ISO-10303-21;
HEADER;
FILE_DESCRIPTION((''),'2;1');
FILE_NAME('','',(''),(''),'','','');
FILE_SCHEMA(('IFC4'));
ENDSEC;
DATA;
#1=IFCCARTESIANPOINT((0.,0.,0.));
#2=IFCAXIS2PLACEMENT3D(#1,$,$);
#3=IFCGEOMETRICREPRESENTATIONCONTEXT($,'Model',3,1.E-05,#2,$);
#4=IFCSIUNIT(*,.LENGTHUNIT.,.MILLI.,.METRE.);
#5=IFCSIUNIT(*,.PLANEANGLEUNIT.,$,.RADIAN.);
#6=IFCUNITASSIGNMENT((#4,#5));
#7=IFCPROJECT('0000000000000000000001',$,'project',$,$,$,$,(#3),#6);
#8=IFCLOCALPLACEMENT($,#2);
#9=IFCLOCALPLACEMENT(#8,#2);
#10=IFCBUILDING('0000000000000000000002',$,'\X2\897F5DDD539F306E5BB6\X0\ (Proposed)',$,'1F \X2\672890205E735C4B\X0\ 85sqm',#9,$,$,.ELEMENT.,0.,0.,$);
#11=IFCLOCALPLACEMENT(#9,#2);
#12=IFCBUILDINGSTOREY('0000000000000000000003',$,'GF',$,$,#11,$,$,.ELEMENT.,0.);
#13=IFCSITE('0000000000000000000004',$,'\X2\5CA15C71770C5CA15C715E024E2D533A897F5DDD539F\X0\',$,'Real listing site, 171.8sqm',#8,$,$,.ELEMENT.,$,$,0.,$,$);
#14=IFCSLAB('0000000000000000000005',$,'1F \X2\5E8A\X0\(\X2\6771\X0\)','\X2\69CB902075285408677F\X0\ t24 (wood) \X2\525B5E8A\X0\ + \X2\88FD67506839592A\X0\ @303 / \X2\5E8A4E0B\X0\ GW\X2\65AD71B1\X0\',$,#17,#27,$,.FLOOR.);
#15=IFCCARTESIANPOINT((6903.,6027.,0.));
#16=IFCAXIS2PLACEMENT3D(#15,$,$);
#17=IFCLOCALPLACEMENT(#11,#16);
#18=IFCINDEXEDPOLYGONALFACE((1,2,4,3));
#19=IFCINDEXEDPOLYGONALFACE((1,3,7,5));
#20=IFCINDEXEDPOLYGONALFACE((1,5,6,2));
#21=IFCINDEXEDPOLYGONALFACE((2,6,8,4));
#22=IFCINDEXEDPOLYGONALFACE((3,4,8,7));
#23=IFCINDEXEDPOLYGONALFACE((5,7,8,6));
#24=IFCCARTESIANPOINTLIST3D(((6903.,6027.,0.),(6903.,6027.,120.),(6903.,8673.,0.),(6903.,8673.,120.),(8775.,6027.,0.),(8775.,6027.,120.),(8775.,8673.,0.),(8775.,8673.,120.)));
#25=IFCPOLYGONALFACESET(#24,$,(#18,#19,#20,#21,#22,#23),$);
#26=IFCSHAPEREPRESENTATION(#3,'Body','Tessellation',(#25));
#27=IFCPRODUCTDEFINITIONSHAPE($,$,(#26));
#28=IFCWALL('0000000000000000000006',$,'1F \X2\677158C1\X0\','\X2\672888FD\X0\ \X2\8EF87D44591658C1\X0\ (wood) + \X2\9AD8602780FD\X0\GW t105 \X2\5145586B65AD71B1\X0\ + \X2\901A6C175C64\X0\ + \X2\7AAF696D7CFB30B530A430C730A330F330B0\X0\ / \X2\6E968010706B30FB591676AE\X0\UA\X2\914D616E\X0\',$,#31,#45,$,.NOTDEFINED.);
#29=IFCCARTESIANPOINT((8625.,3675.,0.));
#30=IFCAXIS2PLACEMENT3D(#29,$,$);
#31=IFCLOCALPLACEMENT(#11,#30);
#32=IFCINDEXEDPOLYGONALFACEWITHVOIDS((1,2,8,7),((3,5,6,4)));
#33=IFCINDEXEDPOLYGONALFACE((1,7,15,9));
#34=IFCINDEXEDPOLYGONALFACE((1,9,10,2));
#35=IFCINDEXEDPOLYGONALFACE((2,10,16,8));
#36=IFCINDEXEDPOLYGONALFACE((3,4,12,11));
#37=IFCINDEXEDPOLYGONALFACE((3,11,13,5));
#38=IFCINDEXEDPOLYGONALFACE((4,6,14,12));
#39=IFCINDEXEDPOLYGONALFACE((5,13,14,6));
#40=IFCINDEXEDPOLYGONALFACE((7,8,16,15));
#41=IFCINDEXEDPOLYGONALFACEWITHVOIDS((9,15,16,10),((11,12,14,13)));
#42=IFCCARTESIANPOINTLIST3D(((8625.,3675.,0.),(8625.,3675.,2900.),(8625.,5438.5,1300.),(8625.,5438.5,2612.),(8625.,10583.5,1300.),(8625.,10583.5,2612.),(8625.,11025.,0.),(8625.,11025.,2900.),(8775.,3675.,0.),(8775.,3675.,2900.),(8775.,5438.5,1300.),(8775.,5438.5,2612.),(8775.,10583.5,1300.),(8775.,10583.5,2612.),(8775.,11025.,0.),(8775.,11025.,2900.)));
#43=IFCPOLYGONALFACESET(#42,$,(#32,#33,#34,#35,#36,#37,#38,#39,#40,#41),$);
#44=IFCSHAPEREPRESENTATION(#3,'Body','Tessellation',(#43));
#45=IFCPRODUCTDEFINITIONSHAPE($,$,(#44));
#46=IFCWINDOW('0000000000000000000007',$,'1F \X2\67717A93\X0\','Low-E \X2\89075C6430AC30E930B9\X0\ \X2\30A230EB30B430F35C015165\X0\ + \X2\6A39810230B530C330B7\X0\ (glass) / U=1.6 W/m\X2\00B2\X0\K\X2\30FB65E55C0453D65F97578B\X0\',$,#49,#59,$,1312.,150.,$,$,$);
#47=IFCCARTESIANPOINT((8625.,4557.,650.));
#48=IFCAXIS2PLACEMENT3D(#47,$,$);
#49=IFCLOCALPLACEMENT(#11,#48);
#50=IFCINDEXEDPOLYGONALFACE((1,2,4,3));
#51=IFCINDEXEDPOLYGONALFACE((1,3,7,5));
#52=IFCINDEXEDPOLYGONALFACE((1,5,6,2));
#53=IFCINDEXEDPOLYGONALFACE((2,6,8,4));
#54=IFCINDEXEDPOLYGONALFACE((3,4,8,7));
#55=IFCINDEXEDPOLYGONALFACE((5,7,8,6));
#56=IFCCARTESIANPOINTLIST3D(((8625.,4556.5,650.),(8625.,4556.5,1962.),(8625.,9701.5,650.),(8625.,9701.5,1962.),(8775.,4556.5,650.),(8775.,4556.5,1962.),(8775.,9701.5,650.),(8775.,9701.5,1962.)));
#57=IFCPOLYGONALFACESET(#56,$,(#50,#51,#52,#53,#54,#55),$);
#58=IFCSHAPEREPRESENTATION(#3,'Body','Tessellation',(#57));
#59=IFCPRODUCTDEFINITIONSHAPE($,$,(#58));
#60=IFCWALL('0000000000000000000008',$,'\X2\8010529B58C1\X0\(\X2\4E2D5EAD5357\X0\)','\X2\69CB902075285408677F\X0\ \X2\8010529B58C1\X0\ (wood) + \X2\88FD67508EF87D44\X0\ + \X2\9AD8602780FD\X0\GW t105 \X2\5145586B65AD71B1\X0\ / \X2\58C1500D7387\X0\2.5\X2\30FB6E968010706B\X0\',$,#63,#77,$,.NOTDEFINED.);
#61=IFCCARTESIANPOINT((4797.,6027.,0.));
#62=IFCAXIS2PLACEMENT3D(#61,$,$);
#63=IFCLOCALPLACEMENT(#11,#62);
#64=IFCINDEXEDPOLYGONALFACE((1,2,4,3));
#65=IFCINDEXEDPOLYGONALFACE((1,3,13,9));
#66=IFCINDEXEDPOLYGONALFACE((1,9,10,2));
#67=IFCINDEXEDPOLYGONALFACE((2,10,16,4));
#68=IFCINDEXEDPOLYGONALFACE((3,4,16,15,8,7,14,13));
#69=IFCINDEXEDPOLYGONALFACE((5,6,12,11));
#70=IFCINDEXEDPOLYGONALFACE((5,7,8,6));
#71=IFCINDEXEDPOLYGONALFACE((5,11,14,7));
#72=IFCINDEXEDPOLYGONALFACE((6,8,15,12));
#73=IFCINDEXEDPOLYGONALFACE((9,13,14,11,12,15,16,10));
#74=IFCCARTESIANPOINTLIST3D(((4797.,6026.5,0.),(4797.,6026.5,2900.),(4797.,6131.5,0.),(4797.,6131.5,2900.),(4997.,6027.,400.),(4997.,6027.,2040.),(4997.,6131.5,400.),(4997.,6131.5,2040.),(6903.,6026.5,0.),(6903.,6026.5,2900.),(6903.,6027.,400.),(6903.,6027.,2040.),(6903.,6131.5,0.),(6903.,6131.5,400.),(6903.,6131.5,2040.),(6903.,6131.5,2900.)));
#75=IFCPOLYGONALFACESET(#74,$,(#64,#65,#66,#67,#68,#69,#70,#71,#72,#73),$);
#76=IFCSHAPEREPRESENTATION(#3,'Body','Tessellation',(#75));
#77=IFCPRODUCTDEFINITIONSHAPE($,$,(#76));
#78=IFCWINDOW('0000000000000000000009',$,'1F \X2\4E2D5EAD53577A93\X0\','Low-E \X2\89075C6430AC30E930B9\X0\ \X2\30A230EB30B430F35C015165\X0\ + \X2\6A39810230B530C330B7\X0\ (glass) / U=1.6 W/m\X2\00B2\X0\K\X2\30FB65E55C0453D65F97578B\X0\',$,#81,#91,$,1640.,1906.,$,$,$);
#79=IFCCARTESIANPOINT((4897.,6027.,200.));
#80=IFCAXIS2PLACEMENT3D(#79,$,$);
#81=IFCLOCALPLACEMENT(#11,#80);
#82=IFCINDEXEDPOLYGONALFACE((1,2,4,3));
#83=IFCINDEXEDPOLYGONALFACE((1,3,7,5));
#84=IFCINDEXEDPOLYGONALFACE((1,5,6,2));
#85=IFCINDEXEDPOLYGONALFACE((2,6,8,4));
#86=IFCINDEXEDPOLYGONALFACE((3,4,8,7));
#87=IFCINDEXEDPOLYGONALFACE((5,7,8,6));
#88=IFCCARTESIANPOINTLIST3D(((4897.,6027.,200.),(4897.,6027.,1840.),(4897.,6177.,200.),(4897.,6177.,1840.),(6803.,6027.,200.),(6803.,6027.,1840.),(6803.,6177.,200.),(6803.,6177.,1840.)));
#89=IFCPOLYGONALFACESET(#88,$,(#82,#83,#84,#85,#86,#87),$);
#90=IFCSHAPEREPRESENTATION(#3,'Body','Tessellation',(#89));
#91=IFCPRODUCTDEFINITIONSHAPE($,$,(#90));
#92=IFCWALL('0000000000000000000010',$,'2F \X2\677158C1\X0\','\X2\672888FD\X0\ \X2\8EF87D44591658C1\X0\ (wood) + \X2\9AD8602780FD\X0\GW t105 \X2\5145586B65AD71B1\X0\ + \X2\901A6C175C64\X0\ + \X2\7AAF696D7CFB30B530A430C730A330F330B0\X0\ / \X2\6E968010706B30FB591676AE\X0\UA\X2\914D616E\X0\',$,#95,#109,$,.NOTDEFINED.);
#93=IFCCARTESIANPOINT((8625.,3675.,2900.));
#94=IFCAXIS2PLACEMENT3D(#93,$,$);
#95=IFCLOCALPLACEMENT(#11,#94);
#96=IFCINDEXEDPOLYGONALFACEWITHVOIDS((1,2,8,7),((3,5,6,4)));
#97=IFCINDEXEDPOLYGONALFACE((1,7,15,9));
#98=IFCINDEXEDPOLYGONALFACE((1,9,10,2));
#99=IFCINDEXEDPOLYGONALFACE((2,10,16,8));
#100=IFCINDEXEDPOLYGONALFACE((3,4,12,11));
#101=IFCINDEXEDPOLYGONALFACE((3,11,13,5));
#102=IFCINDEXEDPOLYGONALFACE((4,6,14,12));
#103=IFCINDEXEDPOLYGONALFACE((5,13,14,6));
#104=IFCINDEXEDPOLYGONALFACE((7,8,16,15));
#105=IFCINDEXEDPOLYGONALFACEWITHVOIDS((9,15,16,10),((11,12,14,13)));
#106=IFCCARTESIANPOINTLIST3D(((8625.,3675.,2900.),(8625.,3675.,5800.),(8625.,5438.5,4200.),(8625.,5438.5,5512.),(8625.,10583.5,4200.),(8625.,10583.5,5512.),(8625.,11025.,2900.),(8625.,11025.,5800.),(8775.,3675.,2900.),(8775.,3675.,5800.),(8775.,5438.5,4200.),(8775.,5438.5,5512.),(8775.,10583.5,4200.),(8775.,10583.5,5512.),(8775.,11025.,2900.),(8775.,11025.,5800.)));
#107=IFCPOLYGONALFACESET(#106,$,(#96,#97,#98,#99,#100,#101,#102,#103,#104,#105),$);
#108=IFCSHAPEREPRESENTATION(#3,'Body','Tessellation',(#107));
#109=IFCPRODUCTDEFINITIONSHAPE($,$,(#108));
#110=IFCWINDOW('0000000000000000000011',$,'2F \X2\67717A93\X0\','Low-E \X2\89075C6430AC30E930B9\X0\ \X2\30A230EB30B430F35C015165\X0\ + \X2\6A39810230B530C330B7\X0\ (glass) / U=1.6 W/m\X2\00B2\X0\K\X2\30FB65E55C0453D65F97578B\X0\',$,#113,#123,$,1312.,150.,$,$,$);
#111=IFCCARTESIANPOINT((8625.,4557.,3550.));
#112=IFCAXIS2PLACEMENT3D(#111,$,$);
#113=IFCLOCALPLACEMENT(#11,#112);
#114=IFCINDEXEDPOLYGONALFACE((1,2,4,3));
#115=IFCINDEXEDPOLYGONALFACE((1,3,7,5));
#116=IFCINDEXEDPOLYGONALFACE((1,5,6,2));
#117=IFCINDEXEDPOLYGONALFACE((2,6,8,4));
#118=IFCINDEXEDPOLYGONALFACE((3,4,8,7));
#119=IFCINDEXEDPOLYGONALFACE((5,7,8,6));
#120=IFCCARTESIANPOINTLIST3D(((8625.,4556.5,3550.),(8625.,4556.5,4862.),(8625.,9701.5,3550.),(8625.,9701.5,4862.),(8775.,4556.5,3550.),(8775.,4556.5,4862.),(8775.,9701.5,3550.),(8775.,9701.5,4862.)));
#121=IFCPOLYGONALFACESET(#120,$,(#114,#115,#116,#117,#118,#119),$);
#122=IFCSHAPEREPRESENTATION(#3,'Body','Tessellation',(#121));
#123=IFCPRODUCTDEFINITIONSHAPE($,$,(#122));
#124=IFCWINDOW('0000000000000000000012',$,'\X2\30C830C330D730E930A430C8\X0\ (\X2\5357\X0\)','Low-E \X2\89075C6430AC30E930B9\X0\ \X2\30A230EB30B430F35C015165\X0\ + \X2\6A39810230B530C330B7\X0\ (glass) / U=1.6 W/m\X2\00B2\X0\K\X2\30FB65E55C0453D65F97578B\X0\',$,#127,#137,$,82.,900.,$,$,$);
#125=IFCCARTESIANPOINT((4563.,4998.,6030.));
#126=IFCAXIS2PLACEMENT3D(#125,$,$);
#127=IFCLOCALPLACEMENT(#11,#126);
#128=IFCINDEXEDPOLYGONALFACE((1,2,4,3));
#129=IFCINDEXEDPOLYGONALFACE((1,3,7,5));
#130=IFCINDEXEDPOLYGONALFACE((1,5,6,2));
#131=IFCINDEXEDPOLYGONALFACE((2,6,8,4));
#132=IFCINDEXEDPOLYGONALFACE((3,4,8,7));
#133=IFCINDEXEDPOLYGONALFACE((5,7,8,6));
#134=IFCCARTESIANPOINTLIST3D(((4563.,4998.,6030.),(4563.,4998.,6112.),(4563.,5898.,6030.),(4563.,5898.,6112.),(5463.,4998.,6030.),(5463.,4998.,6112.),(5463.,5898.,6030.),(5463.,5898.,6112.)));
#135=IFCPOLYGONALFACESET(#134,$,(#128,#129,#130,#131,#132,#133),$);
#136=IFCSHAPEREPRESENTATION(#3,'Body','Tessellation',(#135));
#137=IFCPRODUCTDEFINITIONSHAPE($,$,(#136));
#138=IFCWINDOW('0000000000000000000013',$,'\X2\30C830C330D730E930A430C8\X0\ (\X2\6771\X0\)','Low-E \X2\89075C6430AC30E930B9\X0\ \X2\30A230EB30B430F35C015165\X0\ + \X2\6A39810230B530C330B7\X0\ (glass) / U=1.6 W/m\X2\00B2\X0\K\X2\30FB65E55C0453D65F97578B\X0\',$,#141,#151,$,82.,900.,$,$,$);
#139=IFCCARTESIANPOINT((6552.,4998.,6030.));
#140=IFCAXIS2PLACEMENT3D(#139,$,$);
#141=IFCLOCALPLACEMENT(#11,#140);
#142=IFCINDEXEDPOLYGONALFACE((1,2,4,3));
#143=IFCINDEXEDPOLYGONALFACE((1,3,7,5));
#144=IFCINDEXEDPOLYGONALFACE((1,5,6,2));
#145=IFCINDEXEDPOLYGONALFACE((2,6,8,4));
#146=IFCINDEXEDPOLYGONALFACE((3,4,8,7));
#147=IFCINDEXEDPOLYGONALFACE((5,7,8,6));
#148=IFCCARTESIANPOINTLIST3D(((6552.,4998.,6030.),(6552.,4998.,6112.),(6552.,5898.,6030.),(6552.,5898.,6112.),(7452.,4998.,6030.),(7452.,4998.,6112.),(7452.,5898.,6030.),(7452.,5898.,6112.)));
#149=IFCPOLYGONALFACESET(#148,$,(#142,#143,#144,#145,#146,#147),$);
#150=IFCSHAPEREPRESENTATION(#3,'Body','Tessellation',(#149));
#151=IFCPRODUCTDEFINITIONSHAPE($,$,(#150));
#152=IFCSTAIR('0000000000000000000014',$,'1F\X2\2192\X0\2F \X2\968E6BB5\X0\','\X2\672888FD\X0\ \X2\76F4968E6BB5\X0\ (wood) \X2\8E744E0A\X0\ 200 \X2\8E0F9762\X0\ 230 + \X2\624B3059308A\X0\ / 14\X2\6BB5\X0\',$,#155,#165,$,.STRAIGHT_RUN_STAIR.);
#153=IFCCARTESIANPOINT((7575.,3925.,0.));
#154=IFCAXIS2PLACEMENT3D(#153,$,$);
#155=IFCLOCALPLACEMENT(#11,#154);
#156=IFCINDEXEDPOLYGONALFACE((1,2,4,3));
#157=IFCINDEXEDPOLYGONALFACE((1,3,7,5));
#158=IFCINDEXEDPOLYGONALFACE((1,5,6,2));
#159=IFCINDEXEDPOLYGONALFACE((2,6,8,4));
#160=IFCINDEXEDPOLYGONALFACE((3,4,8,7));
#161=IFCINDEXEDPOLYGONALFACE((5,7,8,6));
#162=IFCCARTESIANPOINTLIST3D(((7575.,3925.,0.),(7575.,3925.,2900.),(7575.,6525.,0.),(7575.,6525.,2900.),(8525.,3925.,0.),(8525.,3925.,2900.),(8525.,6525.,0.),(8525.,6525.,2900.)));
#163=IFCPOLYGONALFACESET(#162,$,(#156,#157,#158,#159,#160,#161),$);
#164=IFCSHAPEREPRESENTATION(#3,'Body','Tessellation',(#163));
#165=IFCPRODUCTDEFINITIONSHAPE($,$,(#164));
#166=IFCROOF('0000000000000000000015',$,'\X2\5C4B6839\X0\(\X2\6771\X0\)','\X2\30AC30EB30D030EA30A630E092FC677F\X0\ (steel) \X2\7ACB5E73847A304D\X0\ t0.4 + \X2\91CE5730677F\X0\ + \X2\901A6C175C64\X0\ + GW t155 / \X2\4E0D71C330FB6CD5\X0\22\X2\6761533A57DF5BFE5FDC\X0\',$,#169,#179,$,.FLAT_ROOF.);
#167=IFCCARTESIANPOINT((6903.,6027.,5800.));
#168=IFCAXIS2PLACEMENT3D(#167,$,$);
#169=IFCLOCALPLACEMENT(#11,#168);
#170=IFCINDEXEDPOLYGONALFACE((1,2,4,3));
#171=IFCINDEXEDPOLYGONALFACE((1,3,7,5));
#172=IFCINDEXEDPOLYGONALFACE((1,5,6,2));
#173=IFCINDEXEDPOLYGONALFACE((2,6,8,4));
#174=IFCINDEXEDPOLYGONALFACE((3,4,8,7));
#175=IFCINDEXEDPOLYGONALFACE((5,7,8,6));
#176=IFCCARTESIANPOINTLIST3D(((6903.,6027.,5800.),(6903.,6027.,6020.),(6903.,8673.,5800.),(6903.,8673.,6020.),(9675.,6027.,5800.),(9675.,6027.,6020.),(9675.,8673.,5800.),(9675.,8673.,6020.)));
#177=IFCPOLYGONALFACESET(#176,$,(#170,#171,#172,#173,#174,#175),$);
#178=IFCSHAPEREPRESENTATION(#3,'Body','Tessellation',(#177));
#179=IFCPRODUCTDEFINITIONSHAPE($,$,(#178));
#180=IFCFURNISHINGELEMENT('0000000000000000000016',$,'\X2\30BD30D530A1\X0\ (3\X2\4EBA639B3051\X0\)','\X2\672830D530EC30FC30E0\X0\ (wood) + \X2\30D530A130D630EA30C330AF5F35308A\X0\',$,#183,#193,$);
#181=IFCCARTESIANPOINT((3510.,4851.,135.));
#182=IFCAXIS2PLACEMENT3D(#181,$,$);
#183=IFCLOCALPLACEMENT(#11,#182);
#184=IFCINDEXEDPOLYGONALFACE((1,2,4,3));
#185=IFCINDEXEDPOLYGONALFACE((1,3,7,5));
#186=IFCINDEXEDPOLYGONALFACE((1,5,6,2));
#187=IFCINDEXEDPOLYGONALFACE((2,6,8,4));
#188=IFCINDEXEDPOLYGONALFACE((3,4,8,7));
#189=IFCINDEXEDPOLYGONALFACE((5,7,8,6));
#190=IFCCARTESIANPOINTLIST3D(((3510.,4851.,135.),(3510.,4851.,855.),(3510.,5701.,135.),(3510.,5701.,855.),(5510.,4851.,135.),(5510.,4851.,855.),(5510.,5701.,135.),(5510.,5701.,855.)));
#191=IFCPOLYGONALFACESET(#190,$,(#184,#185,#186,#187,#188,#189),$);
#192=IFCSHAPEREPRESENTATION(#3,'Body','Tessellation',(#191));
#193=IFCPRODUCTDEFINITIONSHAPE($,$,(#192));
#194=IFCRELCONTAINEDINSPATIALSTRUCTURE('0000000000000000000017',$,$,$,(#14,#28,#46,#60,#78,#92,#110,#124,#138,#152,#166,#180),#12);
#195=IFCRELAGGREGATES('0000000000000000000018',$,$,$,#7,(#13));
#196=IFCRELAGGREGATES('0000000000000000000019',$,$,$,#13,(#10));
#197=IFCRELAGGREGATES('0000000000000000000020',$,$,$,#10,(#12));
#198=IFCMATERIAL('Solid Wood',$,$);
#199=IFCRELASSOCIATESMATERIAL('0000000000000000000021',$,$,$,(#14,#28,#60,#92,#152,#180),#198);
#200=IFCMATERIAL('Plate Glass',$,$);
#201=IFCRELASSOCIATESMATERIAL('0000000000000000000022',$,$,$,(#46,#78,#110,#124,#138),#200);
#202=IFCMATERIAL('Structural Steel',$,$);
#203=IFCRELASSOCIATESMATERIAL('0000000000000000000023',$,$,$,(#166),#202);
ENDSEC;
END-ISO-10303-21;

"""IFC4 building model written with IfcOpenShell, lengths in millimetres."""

from ifc_helpers import new_model, si_unit, frame, frame_2d, origin, place, context, project, spatial, rectangle, extrude, material, element, fill, save


model = new_model("IFC4")

# Units and contexts
model_context = context("Model", 3, precision=1e-05, world=origin())
ifc_project = project(units=[si_unit("LENGTHUNIT", "METRE", prefix="MILLI"), si_unit("PLANEANGLEUNIT", "RADIAN")], contexts=[model_context])

# Site, building, storey
site_placement = place(None, origin())
site = spatial("IfcSite", under=ifc_project, at=site_placement, Name="岡山県岡山市中区西川原", ObjectType="Real listing site, 171.8sqm", CompositionType="ELEMENT", RefElevation=0.0)
building_placement = place(site_placement, origin())
building = spatial("IfcBuilding", under=site, at=building_placement, Name="西川原の家 (Proposed)", ObjectType="1F 木造平屋 85sqm", CompositionType="ELEMENT", ElevationOfRefHeight=0.0, ElevationOfTerrain=0.0)
storey_placement = place(building_placement, origin())
storey = spatial("IfcBuildingStorey", under=building, at=storey_placement, Name="GF", CompositionType="ELEMENT", Elevation=0.0)

# Slab
ifc_material_1 = material(Name="Solid Wood")
slab_placement = place(storey_placement, frame((6903.0, 6027.0, 0.0)))
element("IfcSlab", 1, at=slab_placement, inside=storey, material=ifc_material_1, Name="1F 床(東)", Description="構造用合板 t24 (wood) 剛床 + 製材根太 @303 / 床下 GW断熱", PredefinedType="FLOOR", context=model_context, shape_type="SweptSolid", body=[
    extrude(rectangle(XDim=1872.0, YDim=2646.0, at=frame_2d((936.0, 1323.0))), frame((6903.0, 6027.0, 0.0)), (0.0, 0.0, 1.0), 120.0),
])

# Walls, openings, windows
wall_1_placement = place(storey_placement, frame((8625.0, 3675.0, 0.0)))
wall_1 = element("IfcWall", 2, at=wall_1_placement, inside=storey, material=ifc_material_1, Name="1F 東壁", Description="木製 軸組外壁 (wood) + 高性能GW t105 充填断熱 + 通気層 + 窯業系サイディング / 準耐火・外皮UA配慮", PredefinedType="NOTDEFINED", context=model_context, shape_type="SweptSolid", body=[
    extrude(rectangle(XDim=150.0, YDim=7350.0, at=frame_2d((75.0, 3675.0))), frame((8625.0, 3675.0, 0.0)), (0.0, 0.0, 1.0), 2900.0),
])
opening_1_placement = place(storey_placement, frame((8625.0, 4557.0, 650.0)))
opening_1 = element("IfcOpeningElement", 3, at=opening_1_placement, cuts=wall_1, PredefinedType="NOTDEFINED", context=model_context, shape_type="SweptSolid", body=[
    extrude(rectangle(XDim=150.0, YDim=5145.0, at=frame_2d((75.0, 2572.0))), frame((8625.0, 4557.0, 650.0)), (0.0, 0.0, 1.0), 1312.0),
])
ifc_material_2 = material(Name="Plate Glass")
window_1_placement = place(storey_placement, frame((8625.0, 4557.0, 650.0)))
window_1 = element("IfcWindow", 4, at=window_1_placement, inside=storey, material=ifc_material_2, Name="1F 東窓", Description="Low-E 複層ガラス アルゴン封入 + 樹脂サッシ (glass) / U=1.6 W/m²K・日射取得型", OverallHeight=1312.0, OverallWidth=150.0, context=model_context, shape_type="SweptSolid", body=[
    extrude(rectangle(XDim=150.0, YDim=5145.0, at=frame_2d((75.0, 2572.0))), frame((8625.0, 4557.0, 650.0)), (0.0, 0.0, 1.0), 1312.0),
])
fill(opening_1, window_1)
wall_2_placement = place(storey_placement, frame((4797.0, 6027.0, 0.0)))
wall_2 = element("IfcWall", 5, at=wall_2_placement, inside=storey, material=ifc_material_1, Name="耐力壁(中庭南)", Description="構造用合板 耐力壁 (wood) + 製材軸組 + 高性能GW t105 充填断熱 / 壁倍率2.5・準耐火", PredefinedType="NOTDEFINED", context=model_context, shape_type="SweptSolid", body=[
    extrude(rectangle(XDim=2106.0, YDim=105.0, at=frame_2d((1053.0, 52.0))), frame((4797.0, 6027.0, 0.0)), (0.0, 0.0, 1.0), 2900.0),
])
opening_2_placement = place(storey_placement, frame((4897.0, 6027.0, 200.0)))
opening_2 = element("IfcOpeningElement", 6, at=opening_2_placement, cuts=wall_2, PredefinedType="NOTDEFINED", context=model_context, shape_type="SweptSolid", body=[
    extrude(rectangle(XDim=1906.0, YDim=150.0, at=frame_2d((953.0, 75.0))), frame((4897.0, 6027.0, 200.0)), (0.0, 0.0, 1.0), 1640.0),
])
window_2_placement = place(storey_placement, frame((4897.0, 6027.0, 200.0)))
window_2 = element("IfcWindow", 7, at=window_2_placement, inside=storey, material=ifc_material_2, Name="1F 中庭南窓", Description="Low-E 複層ガラス アルゴン封入 + 樹脂サッシ (glass) / U=1.6 W/m²K・日射取得型", OverallHeight=1640.0, OverallWidth=1906.0, context=model_context, shape_type="SweptSolid", body=[
    extrude(rectangle(XDim=1906.0, YDim=150.0, at=frame_2d((953.0, 75.0))), frame((4897.0, 6027.0, 200.0)), (0.0, 0.0, 1.0), 1640.0),
])
fill(opening_2, window_2)

# Wall, opening, window
wall_3_placement = place(storey_placement, frame((8625.0, 3675.0, 2900.0)))
wall_3 = element("IfcWall", 8, at=wall_3_placement, inside=storey, material=ifc_material_1, Name="2F 東壁", Description="木製 軸組外壁 (wood) + 高性能GW t105 充填断熱 + 通気層 + 窯業系サイディング / 準耐火・外皮UA配慮", PredefinedType="NOTDEFINED", context=model_context, shape_type="SweptSolid", body=[
    extrude(rectangle(XDim=150.0, YDim=7350.0, at=frame_2d((75.0, 3675.0))), frame((8625.0, 3675.0, 2900.0)), (0.0, 0.0, 1.0), 2900.0),
])
opening_3_placement = place(storey_placement, frame((8625.0, 4557.0, 3550.0)))
opening_3 = element("IfcOpeningElement", 9, at=opening_3_placement, cuts=wall_3, PredefinedType="NOTDEFINED", context=model_context, shape_type="SweptSolid", body=[
    extrude(rectangle(XDim=150.0, YDim=5145.0, at=frame_2d((75.0, 2572.0))), frame((8625.0, 4557.0, 3550.0)), (0.0, 0.0, 1.0), 1312.0),
])
window_3_placement = place(storey_placement, frame((8625.0, 4557.0, 3550.0)))
window_3 = element("IfcWindow", 10, at=window_3_placement, inside=storey, material=ifc_material_2, Name="2F 東窓", Description="Low-E 複層ガラス アルゴン封入 + 樹脂サッシ (glass) / U=1.6 W/m²K・日射取得型", OverallHeight=1312.0, OverallWidth=150.0, context=model_context, shape_type="SweptSolid", body=[
    extrude(rectangle(XDim=150.0, YDim=5145.0, at=frame_2d((75.0, 2572.0))), frame((8625.0, 4557.0, 3550.0)), (0.0, 0.0, 1.0), 1312.0),
])
fill(opening_3, window_3)

# Windows
window_4_placement = place(storey_placement, frame((4563.0, 4998.0, 6030.0)))
element("IfcWindow", 11, at=window_4_placement, inside=storey, material=ifc_material_2, Name="トップライト (南)", Description="Low-E 複層ガラス アルゴン封入 + 樹脂サッシ (glass) / U=1.6 W/m²K・日射取得型", OverallHeight=82.0, OverallWidth=900.0, context=model_context, shape_type="SweptSolid", body=[
    extrude(rectangle(XDim=900.0, YDim=900.0, at=frame_2d((450.0, 450.0))), frame((4563.0, 4998.0, 6030.0)), (0.0, 0.0, 1.0), 82.0),
])
window_5_placement = place(storey_placement, frame((6552.0, 4998.0, 6030.0)))
element("IfcWindow", 12, at=window_5_placement, inside=storey, material=ifc_material_2, Name="トップライト (東)", Description="Low-E 複層ガラス アルゴン封入 + 樹脂サッシ (glass) / U=1.6 W/m²K・日射取得型", OverallHeight=82.0, OverallWidth=900.0, context=model_context, shape_type="SweptSolid", body=[
    extrude(rectangle(XDim=900.0, YDim=900.0, at=frame_2d((450.0, 450.0))), frame((6552.0, 4998.0, 6030.0)), (0.0, 0.0, 1.0), 82.0),
])

# Stair
stair_placement = place(storey_placement, frame((7575.0, 3925.0, 0.0)))
element("IfcStair", 13, at=stair_placement, inside=storey, material=ifc_material_1, Name="1F→2F 階段", Description="木製 直階段 (wood) 蹴上 200 踏面 230 + 手すり / 14段", PredefinedType="STRAIGHT_RUN_STAIR", context=model_context, shape_type="SweptSolid", body=[
    extrude(rectangle(XDim=950.0, YDim=2600.0, at=frame_2d((475.0, 1300.0))), frame((7575.0, 3925.0, 0.0)), (0.0, 0.0, 1.0), 2900.0),
])

# Roof
ifc_material_3 = material(Name="Structural Steel")
roof_placement = place(storey_placement, frame((6903.0, 6027.0, 5800.0)))
element("IfcRoof", 14, at=roof_placement, inside=storey, material=ifc_material_3, Name="屋根(東)", Description="ガルバリウム鋼板 (steel) 立平葺き t0.4 + 野地板 + 通気層 + GW t155 / 不燃・法22条区域対応", PredefinedType="FLAT_ROOF", context=model_context, shape_type="SweptSolid", body=[
    extrude(rectangle(XDim=2772.0, YDim=2646.0, at=frame_2d((1386.0, 1323.0))), frame((6903.0, 6027.0, 5800.0)), (0.0, 0.0, 1.0), 220.0),
])

# Furnishing element
furnishing_1_placement = place(storey_placement, frame((3510.0, 4851.0, 135.0)))
element("IfcFurnishingElement", 15, at=furnishing_1_placement, inside=storey, material=ifc_material_1, Name="ソファ (3人掛け)", Description="木フレーム (wood) + ファブリック張り", context=model_context, shape_type="SweptSolid", body=[
    extrude(rectangle(XDim=2000.0, YDim=850.0, at=frame_2d((1000.0, 425.0))), frame((3510.0, 4851.0, 135.0)), (0.0, 0.0, 1.0), 720.0),
])

save(model, "model.ifc")
